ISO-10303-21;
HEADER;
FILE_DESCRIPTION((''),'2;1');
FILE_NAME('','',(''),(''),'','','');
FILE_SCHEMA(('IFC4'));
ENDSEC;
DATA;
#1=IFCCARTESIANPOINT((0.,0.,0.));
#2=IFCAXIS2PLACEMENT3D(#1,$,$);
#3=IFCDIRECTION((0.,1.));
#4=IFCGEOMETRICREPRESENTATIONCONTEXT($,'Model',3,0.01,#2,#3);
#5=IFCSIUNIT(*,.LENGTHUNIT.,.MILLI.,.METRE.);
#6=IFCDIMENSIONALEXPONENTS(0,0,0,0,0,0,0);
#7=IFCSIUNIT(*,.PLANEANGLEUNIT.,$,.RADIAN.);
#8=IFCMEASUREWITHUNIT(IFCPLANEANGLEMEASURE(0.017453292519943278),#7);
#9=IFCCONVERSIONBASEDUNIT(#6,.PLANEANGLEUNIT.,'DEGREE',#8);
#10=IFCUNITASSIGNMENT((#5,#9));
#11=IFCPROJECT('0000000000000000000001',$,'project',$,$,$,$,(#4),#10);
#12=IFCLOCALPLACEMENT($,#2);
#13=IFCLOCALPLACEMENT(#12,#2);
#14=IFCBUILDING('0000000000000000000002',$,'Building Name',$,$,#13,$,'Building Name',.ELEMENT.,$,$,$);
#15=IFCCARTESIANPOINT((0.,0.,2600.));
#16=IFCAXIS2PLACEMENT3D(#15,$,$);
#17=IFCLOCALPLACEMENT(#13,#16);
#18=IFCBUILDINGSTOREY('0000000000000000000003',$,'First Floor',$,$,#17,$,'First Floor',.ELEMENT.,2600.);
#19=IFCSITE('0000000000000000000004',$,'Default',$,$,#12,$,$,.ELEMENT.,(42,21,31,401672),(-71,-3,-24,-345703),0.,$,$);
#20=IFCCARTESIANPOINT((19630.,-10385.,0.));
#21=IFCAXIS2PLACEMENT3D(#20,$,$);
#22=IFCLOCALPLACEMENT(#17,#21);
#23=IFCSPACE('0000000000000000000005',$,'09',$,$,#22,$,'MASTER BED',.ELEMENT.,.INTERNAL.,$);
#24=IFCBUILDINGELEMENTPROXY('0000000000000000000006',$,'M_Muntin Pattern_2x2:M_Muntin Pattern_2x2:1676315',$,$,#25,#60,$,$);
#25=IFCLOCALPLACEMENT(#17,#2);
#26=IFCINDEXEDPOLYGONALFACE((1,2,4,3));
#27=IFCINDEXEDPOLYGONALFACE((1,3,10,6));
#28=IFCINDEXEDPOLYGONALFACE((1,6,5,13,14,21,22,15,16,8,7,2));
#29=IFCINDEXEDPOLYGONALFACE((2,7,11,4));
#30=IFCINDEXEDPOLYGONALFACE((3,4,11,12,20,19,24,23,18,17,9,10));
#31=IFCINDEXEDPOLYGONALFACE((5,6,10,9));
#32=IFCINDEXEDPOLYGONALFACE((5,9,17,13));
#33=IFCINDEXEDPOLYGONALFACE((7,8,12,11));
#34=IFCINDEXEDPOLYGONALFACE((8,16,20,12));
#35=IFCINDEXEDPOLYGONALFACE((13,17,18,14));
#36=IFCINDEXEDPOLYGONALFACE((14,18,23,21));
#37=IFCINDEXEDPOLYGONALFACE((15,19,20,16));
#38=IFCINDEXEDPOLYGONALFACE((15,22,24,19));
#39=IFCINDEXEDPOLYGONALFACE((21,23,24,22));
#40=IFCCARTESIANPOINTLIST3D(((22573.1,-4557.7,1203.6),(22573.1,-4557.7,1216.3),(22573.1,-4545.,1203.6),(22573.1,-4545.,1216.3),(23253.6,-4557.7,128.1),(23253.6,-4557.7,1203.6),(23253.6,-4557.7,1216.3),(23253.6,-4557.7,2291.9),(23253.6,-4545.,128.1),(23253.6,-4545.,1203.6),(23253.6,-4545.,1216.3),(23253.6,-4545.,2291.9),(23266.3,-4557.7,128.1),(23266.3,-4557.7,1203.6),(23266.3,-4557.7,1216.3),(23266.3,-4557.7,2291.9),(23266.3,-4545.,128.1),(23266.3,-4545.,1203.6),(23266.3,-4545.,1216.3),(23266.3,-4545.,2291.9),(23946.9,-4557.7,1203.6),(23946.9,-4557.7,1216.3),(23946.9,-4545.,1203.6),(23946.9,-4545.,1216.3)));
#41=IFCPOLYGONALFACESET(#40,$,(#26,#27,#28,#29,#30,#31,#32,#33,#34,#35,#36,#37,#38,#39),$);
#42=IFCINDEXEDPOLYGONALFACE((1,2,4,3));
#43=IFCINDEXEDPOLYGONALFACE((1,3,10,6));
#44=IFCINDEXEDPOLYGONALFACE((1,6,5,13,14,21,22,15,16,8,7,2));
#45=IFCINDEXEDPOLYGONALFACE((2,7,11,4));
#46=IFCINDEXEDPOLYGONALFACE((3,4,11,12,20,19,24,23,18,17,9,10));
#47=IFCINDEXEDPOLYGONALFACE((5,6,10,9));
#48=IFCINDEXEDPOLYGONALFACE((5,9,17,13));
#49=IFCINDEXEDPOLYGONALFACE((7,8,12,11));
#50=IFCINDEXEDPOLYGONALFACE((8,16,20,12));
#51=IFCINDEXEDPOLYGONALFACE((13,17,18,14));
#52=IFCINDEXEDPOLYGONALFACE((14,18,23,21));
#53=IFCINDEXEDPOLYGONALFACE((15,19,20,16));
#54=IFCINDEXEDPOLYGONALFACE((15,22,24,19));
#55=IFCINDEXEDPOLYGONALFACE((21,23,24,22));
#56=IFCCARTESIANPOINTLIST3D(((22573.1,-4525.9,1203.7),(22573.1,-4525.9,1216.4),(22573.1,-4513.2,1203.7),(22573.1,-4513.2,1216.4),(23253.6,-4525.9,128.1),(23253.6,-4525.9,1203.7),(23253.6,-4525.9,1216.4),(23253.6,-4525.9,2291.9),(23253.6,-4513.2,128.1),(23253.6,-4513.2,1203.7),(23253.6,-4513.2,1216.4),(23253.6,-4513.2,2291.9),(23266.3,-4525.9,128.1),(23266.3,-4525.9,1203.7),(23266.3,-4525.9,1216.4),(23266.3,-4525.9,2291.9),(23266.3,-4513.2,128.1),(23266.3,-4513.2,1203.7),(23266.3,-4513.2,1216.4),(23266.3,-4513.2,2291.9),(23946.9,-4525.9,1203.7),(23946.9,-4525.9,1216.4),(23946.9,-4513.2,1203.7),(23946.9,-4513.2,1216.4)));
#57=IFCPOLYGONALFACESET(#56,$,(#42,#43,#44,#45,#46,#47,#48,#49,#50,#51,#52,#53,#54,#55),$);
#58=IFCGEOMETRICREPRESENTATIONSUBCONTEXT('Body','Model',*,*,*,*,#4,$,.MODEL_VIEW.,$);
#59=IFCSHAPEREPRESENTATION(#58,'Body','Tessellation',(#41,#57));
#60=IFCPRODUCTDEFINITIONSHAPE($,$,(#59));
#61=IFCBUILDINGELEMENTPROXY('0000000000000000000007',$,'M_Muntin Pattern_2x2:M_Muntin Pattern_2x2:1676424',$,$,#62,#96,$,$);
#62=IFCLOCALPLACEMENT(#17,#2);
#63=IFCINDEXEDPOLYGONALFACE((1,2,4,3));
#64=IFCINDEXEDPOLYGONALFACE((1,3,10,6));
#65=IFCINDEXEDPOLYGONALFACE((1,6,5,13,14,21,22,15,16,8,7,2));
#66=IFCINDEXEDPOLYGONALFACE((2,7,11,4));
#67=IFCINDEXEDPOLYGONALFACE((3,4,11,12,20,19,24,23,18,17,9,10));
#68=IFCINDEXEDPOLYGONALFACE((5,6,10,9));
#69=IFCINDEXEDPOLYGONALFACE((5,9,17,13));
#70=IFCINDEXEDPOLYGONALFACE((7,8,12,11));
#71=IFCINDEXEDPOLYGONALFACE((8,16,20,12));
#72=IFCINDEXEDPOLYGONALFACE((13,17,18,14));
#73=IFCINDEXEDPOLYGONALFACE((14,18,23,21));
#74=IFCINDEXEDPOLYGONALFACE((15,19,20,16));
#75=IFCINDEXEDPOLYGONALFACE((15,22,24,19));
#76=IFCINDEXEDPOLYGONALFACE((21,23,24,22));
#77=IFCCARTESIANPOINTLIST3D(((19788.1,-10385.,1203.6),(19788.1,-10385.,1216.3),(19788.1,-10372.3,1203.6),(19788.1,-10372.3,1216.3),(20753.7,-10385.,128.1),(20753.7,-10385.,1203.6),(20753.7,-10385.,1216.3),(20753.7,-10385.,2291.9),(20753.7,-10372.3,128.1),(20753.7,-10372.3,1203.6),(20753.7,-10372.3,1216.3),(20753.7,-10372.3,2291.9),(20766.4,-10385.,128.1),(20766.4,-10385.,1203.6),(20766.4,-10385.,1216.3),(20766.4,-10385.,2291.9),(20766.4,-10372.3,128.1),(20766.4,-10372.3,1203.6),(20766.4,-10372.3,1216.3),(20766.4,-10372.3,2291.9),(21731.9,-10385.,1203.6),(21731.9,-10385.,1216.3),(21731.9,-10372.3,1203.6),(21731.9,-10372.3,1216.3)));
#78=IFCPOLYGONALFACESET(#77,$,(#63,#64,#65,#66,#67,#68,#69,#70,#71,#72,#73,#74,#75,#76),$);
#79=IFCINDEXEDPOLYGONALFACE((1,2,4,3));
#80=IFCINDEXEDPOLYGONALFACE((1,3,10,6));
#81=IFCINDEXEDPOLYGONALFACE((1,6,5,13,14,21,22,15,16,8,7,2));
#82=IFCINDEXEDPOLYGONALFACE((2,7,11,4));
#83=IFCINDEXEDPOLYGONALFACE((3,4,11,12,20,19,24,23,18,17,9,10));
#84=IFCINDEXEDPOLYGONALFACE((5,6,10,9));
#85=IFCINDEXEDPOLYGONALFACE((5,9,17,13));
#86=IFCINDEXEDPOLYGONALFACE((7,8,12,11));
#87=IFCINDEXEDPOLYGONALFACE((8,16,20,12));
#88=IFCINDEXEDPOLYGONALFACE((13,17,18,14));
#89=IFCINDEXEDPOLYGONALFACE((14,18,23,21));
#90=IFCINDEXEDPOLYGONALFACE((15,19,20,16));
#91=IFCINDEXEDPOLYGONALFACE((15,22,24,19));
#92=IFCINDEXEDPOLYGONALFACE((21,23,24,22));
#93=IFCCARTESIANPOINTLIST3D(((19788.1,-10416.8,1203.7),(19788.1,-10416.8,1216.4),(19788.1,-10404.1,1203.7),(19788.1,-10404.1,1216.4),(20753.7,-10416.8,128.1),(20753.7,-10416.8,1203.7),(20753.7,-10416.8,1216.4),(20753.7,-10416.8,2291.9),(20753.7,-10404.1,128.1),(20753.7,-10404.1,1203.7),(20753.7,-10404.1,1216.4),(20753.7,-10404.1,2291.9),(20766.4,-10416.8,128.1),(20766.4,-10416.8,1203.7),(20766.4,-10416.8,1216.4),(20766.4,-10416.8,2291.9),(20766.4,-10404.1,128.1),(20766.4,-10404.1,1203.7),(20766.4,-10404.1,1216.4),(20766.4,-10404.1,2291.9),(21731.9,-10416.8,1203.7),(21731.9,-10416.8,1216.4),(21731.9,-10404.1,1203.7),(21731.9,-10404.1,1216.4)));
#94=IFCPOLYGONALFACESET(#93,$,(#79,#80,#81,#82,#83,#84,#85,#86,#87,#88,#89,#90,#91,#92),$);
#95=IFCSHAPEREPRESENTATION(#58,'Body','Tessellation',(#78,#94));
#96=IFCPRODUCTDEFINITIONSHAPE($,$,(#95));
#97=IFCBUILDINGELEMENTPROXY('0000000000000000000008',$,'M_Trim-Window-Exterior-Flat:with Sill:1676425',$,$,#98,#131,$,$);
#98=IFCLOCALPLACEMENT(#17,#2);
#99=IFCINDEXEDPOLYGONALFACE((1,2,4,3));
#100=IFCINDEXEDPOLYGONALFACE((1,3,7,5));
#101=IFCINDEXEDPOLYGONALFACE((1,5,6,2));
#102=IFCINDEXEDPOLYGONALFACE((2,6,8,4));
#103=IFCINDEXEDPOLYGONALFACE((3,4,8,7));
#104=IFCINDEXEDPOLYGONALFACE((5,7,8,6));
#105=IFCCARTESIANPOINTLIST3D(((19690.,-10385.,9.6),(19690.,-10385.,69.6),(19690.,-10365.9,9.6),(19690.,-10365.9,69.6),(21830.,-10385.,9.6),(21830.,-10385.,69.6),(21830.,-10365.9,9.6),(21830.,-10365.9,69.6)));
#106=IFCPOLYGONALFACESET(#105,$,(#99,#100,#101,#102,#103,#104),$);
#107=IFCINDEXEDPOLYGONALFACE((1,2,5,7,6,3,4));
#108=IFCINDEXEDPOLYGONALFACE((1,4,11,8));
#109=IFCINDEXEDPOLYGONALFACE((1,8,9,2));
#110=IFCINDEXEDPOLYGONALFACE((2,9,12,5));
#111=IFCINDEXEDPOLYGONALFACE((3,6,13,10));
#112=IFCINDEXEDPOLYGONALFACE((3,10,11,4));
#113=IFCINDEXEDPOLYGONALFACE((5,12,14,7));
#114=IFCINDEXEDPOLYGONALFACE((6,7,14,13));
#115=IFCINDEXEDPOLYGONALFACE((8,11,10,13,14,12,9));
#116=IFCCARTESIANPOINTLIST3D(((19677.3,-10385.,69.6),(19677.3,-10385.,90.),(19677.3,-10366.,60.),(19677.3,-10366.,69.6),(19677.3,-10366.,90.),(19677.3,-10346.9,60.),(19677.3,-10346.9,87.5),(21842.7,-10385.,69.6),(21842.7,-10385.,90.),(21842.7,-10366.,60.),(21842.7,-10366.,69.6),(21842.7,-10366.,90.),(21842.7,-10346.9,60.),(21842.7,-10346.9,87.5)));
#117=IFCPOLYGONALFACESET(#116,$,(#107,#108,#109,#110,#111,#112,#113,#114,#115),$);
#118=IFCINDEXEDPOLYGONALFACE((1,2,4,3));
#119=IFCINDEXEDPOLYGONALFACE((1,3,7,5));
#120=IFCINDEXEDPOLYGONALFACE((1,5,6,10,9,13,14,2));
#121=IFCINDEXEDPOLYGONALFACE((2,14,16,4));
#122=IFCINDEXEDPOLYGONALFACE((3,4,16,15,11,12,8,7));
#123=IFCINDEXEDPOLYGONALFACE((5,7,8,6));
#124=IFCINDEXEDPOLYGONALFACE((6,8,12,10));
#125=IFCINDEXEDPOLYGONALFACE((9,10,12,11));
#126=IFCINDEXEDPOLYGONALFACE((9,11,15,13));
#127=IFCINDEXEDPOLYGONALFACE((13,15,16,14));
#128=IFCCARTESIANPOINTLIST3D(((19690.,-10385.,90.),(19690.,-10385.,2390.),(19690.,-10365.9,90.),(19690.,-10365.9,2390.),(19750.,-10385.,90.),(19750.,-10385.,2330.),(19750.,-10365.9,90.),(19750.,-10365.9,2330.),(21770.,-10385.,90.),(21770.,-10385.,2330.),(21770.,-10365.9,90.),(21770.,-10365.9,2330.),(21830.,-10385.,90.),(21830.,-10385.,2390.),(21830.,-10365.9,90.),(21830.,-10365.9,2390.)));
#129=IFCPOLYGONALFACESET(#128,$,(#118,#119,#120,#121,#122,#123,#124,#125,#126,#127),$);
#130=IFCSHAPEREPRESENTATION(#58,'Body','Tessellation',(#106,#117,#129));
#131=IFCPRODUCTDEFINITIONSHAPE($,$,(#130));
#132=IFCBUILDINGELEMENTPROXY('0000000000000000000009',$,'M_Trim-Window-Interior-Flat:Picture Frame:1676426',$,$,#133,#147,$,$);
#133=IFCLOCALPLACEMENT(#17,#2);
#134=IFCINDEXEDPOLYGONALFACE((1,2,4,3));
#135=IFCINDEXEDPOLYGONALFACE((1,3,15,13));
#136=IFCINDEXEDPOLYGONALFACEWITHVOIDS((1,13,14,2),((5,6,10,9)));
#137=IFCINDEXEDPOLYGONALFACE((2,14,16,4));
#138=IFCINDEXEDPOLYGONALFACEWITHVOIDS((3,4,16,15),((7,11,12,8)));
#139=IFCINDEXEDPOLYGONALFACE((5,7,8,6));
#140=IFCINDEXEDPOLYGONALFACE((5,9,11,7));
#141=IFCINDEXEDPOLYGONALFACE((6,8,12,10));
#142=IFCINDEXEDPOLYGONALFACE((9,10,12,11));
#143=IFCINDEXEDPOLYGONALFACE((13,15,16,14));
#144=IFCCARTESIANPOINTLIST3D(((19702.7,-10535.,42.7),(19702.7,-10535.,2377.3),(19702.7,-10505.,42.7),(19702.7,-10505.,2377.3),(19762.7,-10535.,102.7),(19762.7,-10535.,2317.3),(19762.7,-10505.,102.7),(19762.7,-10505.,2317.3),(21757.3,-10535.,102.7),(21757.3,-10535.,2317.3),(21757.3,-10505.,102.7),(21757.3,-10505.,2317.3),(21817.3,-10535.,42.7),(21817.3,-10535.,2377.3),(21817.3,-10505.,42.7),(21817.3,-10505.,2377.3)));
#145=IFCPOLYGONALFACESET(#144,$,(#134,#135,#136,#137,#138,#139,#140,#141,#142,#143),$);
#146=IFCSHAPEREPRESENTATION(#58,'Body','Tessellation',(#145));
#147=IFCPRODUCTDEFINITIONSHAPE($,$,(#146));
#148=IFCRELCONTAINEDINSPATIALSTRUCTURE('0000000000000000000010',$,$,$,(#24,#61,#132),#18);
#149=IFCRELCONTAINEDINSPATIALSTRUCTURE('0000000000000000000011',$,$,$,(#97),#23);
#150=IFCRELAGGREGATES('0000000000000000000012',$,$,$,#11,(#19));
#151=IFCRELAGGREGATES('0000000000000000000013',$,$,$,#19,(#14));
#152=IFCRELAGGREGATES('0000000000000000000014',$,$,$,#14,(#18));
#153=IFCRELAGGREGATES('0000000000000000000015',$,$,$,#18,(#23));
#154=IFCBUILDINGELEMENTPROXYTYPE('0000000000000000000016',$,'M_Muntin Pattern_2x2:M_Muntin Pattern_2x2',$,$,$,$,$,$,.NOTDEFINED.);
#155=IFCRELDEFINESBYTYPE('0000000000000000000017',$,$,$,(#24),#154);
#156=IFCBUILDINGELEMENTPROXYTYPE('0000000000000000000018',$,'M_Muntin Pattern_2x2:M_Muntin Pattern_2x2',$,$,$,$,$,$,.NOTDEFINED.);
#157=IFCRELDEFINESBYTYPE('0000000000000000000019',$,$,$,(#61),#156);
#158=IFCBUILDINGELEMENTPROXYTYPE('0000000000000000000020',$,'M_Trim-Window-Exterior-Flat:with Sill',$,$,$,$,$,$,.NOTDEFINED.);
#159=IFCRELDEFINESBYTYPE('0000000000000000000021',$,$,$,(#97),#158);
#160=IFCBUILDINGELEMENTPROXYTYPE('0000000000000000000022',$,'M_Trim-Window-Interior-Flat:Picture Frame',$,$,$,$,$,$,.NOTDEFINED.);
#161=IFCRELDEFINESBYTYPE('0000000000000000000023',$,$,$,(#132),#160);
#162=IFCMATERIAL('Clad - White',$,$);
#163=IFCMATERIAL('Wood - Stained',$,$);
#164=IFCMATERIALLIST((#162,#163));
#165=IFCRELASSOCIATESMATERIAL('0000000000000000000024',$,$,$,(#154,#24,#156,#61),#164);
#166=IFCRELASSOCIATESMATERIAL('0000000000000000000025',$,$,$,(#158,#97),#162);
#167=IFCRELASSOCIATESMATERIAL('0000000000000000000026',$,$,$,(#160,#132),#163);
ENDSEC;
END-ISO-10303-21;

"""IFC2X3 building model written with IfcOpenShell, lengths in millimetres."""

from ifc_helpers import new_model, entity, si_unit, converted_unit, direction, frame, frame_2d, origin, place, context, subcontext, project, spatial, polyline, rectangle, outline, extrude, source, transform, mapped, material, material_list, type_object, type_shapes, element, save


model = new_model("IFC2X3")

# Units and contexts
model_context = context("Model", 3, precision=0.01, world=origin(), true_north=direction((0.0, 1.0)))
body_context = subcontext(model_context, "Body", "Model", "MODEL_VIEW")
ifc_project = project(units=[si_unit("LENGTHUNIT", "METRE", prefix="MILLI"), converted_unit("PLANEANGLEUNIT", "DEGREE", entity("IfcPlaneAngleMeasure", 0.017453292519943278), si_unit("PLANEANGLEUNIT", "RADIAN"), dimensions=[0, 0, 0, 0, 0, 0, 0])], contexts=[model_context])

# Site, building, storey
site_placement = place(None, origin())
site = spatial("IfcSite", under=ifc_project, at=site_placement, Name="Default", CompositionType="ELEMENT", RefLatitude=(42, 21, 31, 401672), RefLongitude=(-71, -3, -24, -345703), RefElevation=0.0)
building_placement = place(site_placement, origin())
building = spatial("IfcBuilding", under=site, at=building_placement, Name="Building Name", LongName="Building Name", CompositionType="ELEMENT")
storey_placement = place(building_placement, frame((0.0, 0.0, 2600.0)))
storey = spatial("IfcBuildingStorey", under=building, at=storey_placement, Name="First Floor", LongName="First Floor", CompositionType="ELEMENT", Elevation=2600.0)

# Shared definitions
space_1_placement = place(storey_placement, frame((19630.0, -10385.0, 0.0)))
space_1 = spatial("IfcSpace", under=storey, at=space_1_placement, Name="09", LongName="MASTER BED", CompositionType="ELEMENT", InteriorOrExteriorSpace="INTERNAL")

# Building element proxies
ifc_material_1 = material(Name="Clad - White")
ifc_material_2 = material(Name="Wood - Stained")
ifc_material_list_1 = material_list([ifc_material_1, ifc_material_2])
building_element_proxy_type_1 = type_object("IfcBuildingElementProxyType", Name="M_Muntin Pattern_2x2:M_Muntin Pattern_2x2", PredefinedType="NOTDEFINED", material=ifc_material_list_1)
shared_shape_1 = source(origin(), body_context, "Body", "SweptSolid", [
    extrude(outline(polyline([(6.4, -6.4), (1081.9, -6.4), (1081.9, 6.3), (6.4, 6.3), (6.4, 686.9), (-6.3, 686.9), (-6.3, 6.3), (-1081.9, 6.3), (-1081.9, -6.4), (-6.3, -6.4), (-6.3, -686.9), (6.4, -686.9), (6.4, -6.4)])), frame((0.0, -22.2, 1081.9), z_axis=(0.0, 1.0, 0.0), x_axis=(0.0, 0.0, 1.0)), (0.0, 0.0, 1.0), 12.7),
    extrude(outline(polyline([(6.4, -6.4), (1081.9, -6.4), (1081.9, 6.3), (6.4, 6.3), (6.4, 686.9), (-6.3, 686.9), (-6.3, 6.3), (-1081.9, 6.3), (-1081.9, -6.4), (-6.3, -6.4), (-6.3, -686.9), (6.4, -686.9), (6.4, -6.4)])), frame((0.0, 9.5, 1081.9), z_axis=(0.0, 1.0, 0.0), x_axis=(0.0, 0.0, 1.0)), (0.0, 0.0, 1.0), 12.7),
])
type_shapes(building_element_proxy_type_1, [shared_shape_1])
proxy_1_placement = place(storey_placement, frame((23260.0, -4535.5, 128.1)))
element("IfcBuildingElementProxy", 1, at=proxy_1_placement, inside=storey, type_object=building_element_proxy_type_1, material=ifc_material_list_1, Name="M_Muntin Pattern_2x2:M_Muntin Pattern_2x2:1676315", context=body_context, shape_type="MappedRepresentation", body=[
    mapped(shared_shape_1, transform((0.0, 0.0, 0.0), scale=1.0)),
])
building_element_proxy_type_2 = type_object("IfcBuildingElementProxyType", Name="M_Muntin Pattern_2x2:M_Muntin Pattern_2x2", PredefinedType="NOTDEFINED", material=ifc_material_list_1)
shared_shape_2 = source(origin(), body_context, "Body", "SweptSolid", [
    extrude(outline(polyline([(6.4, -6.4), (1081.9, -6.4), (1081.9, 6.3), (6.4, 6.3), (6.4, 971.9), (-6.3, 971.9), (-6.3, 6.3), (-1081.9, 6.3), (-1081.9, -6.4), (-6.3, -6.4), (-6.3, -971.9), (6.4, -971.9), (6.4, -6.4)])), frame((0.0, -22.2, 1081.9), z_axis=(0.0, 1.0, 0.0), x_axis=(0.0, 0.0, 1.0)), (0.0, 0.0, 1.0), 12.7),
    extrude(outline(polyline([(6.4, -6.4), (1081.9, -6.4), (1081.9, 6.3), (6.4, 6.3), (6.4, 971.9), (-6.3, 971.9), (-6.3, 6.3), (-1081.9, 6.3), (-1081.9, -6.4), (-6.3, -6.4), (-6.3, -971.9), (6.4, -971.9), (6.4, -6.4)])), frame((0.0, 9.5, 1081.9), z_axis=(0.0, 1.0, 0.0), x_axis=(0.0, 0.0, 1.0)), (0.0, 0.0, 1.0), 12.7),
])
type_shapes(building_element_proxy_type_2, [shared_shape_2])
proxy_2_placement = place(storey_placement, frame((20760.0, -10394.5, 128.1), z_axis=(0.0, 0.0, 1.0), x_axis=(-1.0, 0.0, 0.0)))
element("IfcBuildingElementProxy", 2, at=proxy_2_placement, inside=storey, type_object=building_element_proxy_type_2, material=ifc_material_list_1, Name="M_Muntin Pattern_2x2:M_Muntin Pattern_2x2:1676424", context=body_context, shape_type="MappedRepresentation", body=[
    mapped(shared_shape_2, transform((0.0, 0.0, 0.0), scale=1.0)),
])
building_element_proxy_type_3 = type_object("IfcBuildingElementProxyType", Name="M_Trim-Window-Exterior-Flat:with Sill", PredefinedType="NOTDEFINED", material=ifc_material_1)
shared_shape_3 = source(origin(), body_context, "Body", "SweptSolid", [
    extrude(rectangle(XDim=2140.0, YDim=60.0, at=frame_2d((0.0, 0.0), x_axis=(1.0, 0.0))), frame((0.0, -2290.4, 0.0), z_axis=(0.0, 0.0, 1.0), x_axis=(-1.0, 0.0, 0.0)), (0.0, 0.0, 1.0), 19.0),
    extrude(outline(polyline([(-19.0, -15.2), (0.0, -15.2), (0.0, -5.7), (19.0, -5.7), (19.0, 14.8), (0.0, 14.8), (-19.0, 12.3), (-19.0, -15.2)])), frame((-1082.7, -2254.8, 19.0), z_axis=(1.0, 0.0, 0.0), x_axis=(0.0, 0.0, -1.0)), (0.0, 0.0, 1.0), 2165.4),
    extrude(outline(polyline([(-1165.0, -1070.0), (1135.0, -1070.0), (1135.0, -1010.0), (-1105.0, -1010.0), (-1105.0, 1010.0), (1135.0, 1010.0), (1135.0, 1070.0), (-1165.0, 1070.0), (-1165.0, -1070.0)])), frame((0.0, -1105.0, 0.0), z_axis=(0.0, 0.0, 1.0), x_axis=(0.0, -1.0, 0.0)), (0.0, 0.0, 1.0), 19.0),
])
type_shapes(building_element_proxy_type_3, [shared_shape_3])
proxy_3_placement = place(space_1_placement, frame((1130.0, 0.0, 2330.0), z_axis=(0.0, 1.0, 0.0), x_axis=(-1.0, 0.0, 0.0)))
element("IfcBuildingElementProxy", 3, at=proxy_3_placement, inside=space_1, type_object=building_element_proxy_type_3, material=ifc_material_1, Name="M_Trim-Window-Exterior-Flat:with Sill:1676425", context=body_context, shape_type="MappedRepresentation", body=[
    mapped(shared_shape_3, transform((0.0, 0.0, 0.0), scale=1.0)),
])
building_element_proxy_type_4 = type_object("IfcBuildingElementProxyType", Name="M_Trim-Window-Interior-Flat:Picture Frame", PredefinedType="NOTDEFINED", material=ifc_material_2)
shared_shape_4 = source(origin(), body_context, "Body", "SweptSolid", [
    extrude(outline(polyline([(-1057.3, -1167.3), (1057.3, -1167.3), (1057.3, 1167.3), (-1057.3, 1167.3), (-1057.3, -1167.3)]), holes=[polyline([(-997.3, -1107.3), (-997.3, 1107.3), (997.3, 1107.3), (997.3, -1107.3), (-997.3, -1107.3)])]), frame((0.0, -1120.0, 0.0), z_axis=(0.0, 0.0, 1.0), x_axis=(-1.0, 0.0, 0.0)), (0.0, 0.0, 1.0), 30.0),
])
type_shapes(building_element_proxy_type_4, [shared_shape_4])
proxy_4_placement = place(storey_placement, frame((20760.0, -10505.0, 2330.0), z_axis=(0.0, -1.0, 0.0), x_axis=(1.0, 0.0, 0.0)))
element("IfcBuildingElementProxy", 4, at=proxy_4_placement, inside=storey, type_object=building_element_proxy_type_4, material=ifc_material_2, Name="M_Trim-Window-Interior-Flat:Picture Frame:1676426", context=body_context, shape_type="MappedRepresentation", body=[
    mapped(shared_shape_4, transform((0.0, 0.0, 0.0), scale=1.0)),
])

save(model, "model.ifc")
